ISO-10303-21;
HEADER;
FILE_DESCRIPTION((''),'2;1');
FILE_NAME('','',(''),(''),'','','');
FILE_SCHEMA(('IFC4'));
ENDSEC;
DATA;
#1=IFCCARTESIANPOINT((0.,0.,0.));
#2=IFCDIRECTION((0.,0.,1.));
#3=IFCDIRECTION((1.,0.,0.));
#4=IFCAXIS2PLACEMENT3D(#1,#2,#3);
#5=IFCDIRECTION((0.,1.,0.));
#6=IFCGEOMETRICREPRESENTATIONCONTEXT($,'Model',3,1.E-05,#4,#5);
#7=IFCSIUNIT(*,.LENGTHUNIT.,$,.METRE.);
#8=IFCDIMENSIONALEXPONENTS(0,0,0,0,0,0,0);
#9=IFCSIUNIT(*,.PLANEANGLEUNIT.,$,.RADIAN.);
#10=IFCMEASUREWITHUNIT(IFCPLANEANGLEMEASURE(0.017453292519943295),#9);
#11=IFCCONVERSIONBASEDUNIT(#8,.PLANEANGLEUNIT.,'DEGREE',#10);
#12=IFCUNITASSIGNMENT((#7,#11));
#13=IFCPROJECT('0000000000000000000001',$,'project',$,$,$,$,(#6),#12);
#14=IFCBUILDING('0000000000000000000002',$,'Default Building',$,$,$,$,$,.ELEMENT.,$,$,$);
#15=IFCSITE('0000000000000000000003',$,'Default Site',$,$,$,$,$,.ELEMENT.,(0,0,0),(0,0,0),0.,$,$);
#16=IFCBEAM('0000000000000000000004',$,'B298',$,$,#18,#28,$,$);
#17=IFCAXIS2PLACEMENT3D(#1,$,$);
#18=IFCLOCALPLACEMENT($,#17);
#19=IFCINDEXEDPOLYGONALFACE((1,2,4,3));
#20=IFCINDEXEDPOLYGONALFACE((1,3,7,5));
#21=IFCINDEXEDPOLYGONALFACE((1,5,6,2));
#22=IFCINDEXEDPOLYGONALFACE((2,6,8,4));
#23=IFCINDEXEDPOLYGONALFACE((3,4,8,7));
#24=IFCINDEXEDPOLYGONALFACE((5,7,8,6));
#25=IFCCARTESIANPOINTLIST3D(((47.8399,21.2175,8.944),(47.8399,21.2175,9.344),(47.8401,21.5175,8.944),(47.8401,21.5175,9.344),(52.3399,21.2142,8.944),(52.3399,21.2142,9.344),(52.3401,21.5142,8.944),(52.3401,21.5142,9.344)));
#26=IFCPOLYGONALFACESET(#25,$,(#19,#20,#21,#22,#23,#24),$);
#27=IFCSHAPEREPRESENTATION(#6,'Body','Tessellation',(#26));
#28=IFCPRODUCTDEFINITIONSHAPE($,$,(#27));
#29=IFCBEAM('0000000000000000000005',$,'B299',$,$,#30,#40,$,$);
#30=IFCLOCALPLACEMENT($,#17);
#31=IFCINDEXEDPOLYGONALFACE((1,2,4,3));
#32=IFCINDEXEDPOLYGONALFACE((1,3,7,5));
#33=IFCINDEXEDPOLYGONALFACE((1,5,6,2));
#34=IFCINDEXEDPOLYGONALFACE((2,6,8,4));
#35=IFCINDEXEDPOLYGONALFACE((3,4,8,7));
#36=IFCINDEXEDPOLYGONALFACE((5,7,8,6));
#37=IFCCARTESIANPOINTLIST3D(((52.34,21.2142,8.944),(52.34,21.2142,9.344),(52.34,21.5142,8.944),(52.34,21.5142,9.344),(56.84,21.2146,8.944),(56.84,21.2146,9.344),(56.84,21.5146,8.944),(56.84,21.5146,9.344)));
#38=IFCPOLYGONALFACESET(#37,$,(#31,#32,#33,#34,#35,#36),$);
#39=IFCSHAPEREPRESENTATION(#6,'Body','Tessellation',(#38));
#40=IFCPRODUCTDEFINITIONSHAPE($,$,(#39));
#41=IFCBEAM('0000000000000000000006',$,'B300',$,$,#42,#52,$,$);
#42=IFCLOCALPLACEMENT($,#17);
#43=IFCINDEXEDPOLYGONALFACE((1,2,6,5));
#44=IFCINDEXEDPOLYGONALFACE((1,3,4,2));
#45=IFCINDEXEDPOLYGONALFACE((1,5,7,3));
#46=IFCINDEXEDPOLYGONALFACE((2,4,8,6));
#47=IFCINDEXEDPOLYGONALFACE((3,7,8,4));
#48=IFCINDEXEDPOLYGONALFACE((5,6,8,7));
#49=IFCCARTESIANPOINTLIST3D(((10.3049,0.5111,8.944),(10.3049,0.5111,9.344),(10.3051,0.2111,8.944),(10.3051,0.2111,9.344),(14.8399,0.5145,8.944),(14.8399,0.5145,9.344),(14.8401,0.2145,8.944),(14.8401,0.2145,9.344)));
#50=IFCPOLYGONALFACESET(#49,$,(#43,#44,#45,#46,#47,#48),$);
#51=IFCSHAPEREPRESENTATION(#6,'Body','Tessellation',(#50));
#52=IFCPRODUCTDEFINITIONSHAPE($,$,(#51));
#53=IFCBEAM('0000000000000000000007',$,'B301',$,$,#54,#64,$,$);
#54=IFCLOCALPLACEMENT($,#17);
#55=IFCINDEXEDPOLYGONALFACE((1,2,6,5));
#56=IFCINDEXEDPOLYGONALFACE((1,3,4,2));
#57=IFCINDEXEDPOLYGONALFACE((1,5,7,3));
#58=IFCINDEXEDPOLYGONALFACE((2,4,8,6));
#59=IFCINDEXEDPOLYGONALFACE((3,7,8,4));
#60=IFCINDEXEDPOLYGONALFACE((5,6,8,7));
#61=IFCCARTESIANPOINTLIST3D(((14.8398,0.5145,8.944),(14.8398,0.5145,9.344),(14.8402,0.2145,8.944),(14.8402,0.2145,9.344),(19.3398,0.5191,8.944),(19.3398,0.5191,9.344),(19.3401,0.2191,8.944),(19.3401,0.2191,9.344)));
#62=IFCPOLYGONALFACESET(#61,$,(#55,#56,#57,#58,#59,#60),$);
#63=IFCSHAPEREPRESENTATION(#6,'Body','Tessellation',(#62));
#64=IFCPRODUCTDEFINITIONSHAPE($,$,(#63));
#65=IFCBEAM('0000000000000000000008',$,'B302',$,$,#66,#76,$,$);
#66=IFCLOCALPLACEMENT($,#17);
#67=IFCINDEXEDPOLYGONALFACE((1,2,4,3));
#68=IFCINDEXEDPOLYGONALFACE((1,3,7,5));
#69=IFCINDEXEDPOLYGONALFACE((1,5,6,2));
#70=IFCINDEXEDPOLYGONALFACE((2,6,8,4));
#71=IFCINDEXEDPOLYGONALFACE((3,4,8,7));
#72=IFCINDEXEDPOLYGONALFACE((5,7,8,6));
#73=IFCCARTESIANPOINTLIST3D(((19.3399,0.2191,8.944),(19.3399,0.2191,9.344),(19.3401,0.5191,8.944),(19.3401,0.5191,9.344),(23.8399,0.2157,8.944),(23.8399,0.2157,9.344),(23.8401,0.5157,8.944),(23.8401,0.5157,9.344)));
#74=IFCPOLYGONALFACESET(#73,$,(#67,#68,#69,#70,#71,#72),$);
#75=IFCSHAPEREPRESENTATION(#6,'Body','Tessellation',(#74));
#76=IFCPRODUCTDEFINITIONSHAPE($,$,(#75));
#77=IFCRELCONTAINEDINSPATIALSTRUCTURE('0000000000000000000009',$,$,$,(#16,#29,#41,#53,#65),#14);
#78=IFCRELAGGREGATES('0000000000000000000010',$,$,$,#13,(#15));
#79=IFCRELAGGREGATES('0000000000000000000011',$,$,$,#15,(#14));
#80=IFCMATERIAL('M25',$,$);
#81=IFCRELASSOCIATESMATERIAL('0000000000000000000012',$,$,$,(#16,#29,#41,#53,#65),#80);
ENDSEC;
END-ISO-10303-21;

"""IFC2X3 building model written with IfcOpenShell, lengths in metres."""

from ifc_helpers import new_model, entity, si_unit, converted_unit, direction, frame, frame_2d, origin_with_axes, place, context, project, spatial, rectangle, extrude, material, element, save


model = new_model("IFC2X3")

# Units and contexts
model_context = context("Model", 3, precision=1e-05, world=origin_with_axes(), true_north=direction((0.0, 1.0, 0.0)))
ifc_project = project(units=[si_unit("LENGTHUNIT", "METRE"), converted_unit("PLANEANGLEUNIT", "DEGREE", entity("IfcPlaneAngleMeasure", 0.017453292519943295), si_unit("PLANEANGLEUNIT", "RADIAN"), dimensions=[0, 0, 0, 0, 0, 0, 0])], contexts=[model_context])

# Site, building
site = spatial("IfcSite", under=ifc_project, Name="Default Site", CompositionType="ELEMENT", RefLatitude=(0, 0, 0), RefLongitude=(0, 0, 0), RefElevation=0.0)
building = spatial("IfcBuilding", under=site, Name="Default Building", CompositionType="ELEMENT")

# Shared definitions
ifc_material = material(Name="M25")
placement = place(None, origin_with_axes())

# Beams
element("IfcBeam", 1, at=placement, inside=building, material=ifc_material, Name="B298", context=model_context, shape_type="SweptSolid", body=[
    extrude(rectangle(XDim=0.3, YDim=0.4, at=frame_2d((0.0, 0.0), x_axis=(0.0, 1.0, 0.0))), frame((47.84, 21.3675, 9.144), z_axis=(1.0, -0.000744, 0.0), x_axis=(0.0, 0.0, -1.0)), (0.0, 0.0, 1.0), 4.5),
])
element("IfcBeam", 2, at=placement, inside=building, material=ifc_material, Name="B299", context=model_context, shape_type="SweptSolid", body=[
    extrude(rectangle(XDim=0.3, YDim=0.4, at=frame_2d((0.0, 0.0), x_axis=(0.0, 1.0, 0.0))), frame((52.34, 21.3642, 9.144), z_axis=(1.0, 0.000102, 0.0), x_axis=(0.0, 0.0, -1.0)), (0.0, 0.0, 1.0), 4.5),
])
element("IfcBeam", 3, at=placement, inside=building, material=ifc_material, Name="B300", context=model_context, shape_type="SweptSolid", body=[
    extrude(rectangle(XDim=0.3, YDim=0.4, at=frame_2d((0.0, 0.0), x_axis=(0.0, 1.0, 0.0))), frame((10.305, 0.3611, 9.144), z_axis=(1.0, 0.000762, 0.0), x_axis=(0.0, 0.0, -1.0)), (0.0, 0.0, 1.0), 4.535),
])
element("IfcBeam", 4, at=placement, inside=building, material=ifc_material, Name="B301", context=model_context, shape_type="SweptSolid", body=[
    extrude(rectangle(XDim=0.3, YDim=0.4, at=frame_2d((0.0, 0.0), x_axis=(0.0, 1.0, 0.0))), frame((14.84, 0.3645, 9.144), z_axis=(0.999999, 0.00101, 0.0), x_axis=(0.0, 0.0, -1.0)), (0.0, 0.0, 1.0), 4.5),
])
element("IfcBeam", 5, at=placement, inside=building, material=ifc_material, Name="B302", context=model_context, shape_type="SweptSolid", body=[
    extrude(rectangle(XDim=0.3, YDim=0.4, at=frame_2d((0.0, 0.0), x_axis=(0.0, 1.0, 0.0))), frame((19.34, 0.3691, 9.144), z_axis=(1.0, -0.000757, 0.0), x_axis=(0.0, 0.0, -1.0)), (0.0, 0.0, 1.0), 4.5),
])

save(model, "model.ifc")
